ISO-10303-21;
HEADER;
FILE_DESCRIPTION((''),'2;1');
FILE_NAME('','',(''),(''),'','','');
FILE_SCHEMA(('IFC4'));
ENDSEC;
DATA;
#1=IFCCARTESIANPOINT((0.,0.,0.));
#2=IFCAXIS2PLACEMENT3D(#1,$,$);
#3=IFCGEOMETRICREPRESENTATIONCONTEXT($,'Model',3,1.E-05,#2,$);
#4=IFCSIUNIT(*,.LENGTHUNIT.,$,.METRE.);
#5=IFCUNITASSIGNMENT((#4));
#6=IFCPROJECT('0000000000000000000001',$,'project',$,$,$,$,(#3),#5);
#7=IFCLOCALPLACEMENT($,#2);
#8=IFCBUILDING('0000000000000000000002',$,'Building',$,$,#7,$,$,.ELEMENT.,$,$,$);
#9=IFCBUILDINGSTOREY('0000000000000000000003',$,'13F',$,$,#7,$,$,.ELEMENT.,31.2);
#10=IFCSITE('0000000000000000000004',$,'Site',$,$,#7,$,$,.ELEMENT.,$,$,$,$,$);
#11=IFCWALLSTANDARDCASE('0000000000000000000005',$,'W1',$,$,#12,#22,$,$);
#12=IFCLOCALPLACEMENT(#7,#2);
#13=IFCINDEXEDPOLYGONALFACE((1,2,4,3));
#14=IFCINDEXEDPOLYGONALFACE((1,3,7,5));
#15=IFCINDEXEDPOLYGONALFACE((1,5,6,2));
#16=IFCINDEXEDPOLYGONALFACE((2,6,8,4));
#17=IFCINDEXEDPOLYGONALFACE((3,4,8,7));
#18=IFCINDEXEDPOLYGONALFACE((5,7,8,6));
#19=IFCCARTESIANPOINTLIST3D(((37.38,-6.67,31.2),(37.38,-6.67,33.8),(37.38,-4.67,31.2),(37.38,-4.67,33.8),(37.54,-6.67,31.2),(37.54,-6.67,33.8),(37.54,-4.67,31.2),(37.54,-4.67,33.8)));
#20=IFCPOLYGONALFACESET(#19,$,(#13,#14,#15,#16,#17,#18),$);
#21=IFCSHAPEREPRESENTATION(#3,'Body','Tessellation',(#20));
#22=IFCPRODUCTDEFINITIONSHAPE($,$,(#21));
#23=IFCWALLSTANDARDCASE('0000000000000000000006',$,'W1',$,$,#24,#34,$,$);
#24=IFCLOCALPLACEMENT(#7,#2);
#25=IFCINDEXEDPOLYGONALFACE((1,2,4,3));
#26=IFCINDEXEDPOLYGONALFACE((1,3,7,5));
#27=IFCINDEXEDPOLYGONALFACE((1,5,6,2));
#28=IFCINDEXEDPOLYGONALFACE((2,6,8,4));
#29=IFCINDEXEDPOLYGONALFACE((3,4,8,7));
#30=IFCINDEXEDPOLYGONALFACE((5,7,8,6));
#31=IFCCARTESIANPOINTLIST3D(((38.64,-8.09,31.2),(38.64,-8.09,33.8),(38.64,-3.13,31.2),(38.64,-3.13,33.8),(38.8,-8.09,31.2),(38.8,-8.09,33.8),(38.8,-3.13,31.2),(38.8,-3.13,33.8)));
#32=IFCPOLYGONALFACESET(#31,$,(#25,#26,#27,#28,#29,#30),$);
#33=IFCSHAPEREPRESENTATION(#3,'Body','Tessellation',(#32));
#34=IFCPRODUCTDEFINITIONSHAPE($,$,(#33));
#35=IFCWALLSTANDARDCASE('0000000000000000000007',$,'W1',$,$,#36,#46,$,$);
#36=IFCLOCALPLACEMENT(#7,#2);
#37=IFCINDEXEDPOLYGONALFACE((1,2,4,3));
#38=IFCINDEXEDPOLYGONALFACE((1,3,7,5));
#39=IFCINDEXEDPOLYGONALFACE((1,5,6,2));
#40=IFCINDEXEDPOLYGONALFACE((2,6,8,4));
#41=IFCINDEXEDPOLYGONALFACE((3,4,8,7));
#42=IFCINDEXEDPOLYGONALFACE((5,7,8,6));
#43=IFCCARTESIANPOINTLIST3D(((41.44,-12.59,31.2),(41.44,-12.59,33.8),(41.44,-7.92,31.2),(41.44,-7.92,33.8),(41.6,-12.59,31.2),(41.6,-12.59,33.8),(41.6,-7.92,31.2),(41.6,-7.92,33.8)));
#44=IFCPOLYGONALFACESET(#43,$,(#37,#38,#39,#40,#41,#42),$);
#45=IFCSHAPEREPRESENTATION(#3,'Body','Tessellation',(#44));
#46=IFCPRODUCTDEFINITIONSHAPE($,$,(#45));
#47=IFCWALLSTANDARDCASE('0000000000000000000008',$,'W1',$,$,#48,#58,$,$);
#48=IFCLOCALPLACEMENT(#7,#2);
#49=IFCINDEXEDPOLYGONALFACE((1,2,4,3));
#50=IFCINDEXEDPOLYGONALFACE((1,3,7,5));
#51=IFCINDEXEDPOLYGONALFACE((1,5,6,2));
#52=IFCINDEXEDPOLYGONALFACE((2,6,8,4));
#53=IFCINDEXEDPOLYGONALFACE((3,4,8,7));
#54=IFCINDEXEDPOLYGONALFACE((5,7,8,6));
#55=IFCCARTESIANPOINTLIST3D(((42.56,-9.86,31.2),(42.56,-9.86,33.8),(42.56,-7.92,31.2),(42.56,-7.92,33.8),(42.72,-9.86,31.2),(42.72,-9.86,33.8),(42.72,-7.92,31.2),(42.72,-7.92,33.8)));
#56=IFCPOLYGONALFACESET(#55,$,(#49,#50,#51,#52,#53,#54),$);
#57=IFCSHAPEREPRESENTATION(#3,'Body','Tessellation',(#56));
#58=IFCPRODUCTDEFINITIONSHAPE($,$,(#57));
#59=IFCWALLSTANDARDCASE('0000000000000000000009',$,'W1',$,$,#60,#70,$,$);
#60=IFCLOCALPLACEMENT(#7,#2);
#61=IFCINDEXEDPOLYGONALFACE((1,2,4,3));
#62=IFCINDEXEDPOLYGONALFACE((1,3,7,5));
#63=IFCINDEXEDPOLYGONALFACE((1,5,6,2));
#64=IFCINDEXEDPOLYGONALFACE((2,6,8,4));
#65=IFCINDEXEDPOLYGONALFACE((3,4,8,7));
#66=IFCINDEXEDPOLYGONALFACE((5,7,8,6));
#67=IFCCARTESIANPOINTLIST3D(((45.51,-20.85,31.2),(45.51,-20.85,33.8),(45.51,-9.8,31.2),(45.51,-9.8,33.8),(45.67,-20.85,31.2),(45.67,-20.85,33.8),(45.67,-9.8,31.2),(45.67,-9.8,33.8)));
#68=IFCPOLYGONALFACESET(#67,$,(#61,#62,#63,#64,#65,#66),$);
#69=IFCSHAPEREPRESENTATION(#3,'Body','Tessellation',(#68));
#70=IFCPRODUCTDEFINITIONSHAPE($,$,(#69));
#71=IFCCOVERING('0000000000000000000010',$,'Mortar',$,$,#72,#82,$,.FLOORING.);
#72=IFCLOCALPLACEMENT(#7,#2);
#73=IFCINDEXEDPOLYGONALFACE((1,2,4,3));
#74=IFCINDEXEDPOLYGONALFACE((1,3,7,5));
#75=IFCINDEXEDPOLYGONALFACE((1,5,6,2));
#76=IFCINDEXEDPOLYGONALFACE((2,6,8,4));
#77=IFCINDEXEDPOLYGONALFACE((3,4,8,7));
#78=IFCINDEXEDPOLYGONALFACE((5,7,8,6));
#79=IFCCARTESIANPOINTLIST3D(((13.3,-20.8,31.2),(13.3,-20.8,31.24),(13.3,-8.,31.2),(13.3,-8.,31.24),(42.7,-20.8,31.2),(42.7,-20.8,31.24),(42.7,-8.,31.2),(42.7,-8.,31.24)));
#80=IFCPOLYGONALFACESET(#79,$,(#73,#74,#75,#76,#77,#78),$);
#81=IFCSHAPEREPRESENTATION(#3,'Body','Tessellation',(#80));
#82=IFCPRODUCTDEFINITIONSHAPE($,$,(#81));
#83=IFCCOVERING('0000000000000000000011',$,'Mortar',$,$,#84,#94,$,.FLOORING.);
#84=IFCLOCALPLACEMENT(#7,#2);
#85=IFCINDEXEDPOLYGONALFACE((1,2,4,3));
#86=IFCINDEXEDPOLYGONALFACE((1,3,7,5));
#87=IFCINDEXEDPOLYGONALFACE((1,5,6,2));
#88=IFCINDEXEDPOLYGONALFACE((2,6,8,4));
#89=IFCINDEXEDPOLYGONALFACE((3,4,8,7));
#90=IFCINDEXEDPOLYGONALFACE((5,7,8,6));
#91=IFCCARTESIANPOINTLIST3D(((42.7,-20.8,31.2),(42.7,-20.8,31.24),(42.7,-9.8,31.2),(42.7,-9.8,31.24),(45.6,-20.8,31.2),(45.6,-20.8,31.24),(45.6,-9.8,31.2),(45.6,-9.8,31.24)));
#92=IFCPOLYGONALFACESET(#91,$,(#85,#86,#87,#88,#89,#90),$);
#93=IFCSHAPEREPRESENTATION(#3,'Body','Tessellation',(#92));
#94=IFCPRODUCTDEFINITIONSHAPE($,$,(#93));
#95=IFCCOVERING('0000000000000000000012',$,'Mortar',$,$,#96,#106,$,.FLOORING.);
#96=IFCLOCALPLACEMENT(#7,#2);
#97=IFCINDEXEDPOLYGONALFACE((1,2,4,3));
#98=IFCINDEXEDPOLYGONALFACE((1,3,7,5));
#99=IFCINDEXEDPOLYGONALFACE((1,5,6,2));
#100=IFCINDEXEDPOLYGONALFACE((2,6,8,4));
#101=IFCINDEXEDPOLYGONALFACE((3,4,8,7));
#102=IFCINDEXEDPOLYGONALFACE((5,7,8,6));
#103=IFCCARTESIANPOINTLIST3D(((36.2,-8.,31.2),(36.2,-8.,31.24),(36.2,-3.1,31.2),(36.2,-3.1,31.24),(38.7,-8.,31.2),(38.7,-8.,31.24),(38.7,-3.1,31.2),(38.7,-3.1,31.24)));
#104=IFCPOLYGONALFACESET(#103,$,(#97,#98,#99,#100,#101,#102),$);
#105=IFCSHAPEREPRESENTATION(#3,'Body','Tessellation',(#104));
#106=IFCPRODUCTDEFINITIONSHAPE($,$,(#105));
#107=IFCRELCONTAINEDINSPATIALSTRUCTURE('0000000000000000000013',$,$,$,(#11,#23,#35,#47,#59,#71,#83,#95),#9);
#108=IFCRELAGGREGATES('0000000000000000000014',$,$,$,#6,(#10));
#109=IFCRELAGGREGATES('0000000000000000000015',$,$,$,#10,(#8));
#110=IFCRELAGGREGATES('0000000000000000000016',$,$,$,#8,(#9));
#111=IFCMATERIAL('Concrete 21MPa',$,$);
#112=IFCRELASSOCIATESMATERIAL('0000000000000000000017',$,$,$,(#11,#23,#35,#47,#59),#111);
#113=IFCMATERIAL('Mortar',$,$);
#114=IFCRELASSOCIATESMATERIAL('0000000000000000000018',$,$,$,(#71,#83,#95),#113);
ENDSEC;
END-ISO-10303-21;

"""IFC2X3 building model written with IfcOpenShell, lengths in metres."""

from ifc_helpers import new_model, si_unit, frame, origin, origin_2d, place, context, project, spatial, rectangle, extrude, material, element, save


model = new_model("IFC2X3")

# Units and contexts
model_context = context("Model", 3, precision=1e-05, world=origin())
ifc_project = project(units=[si_unit("LENGTHUNIT", "METRE")], contexts=[model_context])

# Site, building, storey
placement = place(None, origin())
site = spatial("IfcSite", under=ifc_project, at=placement, Name="Site", CompositionType="ELEMENT")
building = spatial("IfcBuilding", under=site, at=placement, Name="Building", CompositionType="ELEMENT")
storey = spatial("IfcBuildingStorey", under=building, at=placement, Name="13F", CompositionType="ELEMENT", Elevation=31.2)

# Shared definitions
ifc_material_1 = material(Name="Concrete 21MPa")

# Walls
wall_1_placement = place(None, frame((37.46, -5.67, 31.2)))
element("IfcWallStandardCase", 1, at=wall_1_placement, inside=storey, material=ifc_material_1, Name="W1", context=model_context, shape_type="SweptSolid", body=[
    extrude(rectangle(XDim=0.16, YDim=2.0, at=origin_2d()), origin(), (0.0, 0.0, 1.0), 2.6),
])
wall_2_placement = place(None, frame((38.72, -5.61, 31.2)))
element("IfcWallStandardCase", 2, at=wall_2_placement, inside=storey, material=ifc_material_1, Name="W1", context=model_context, shape_type="SweptSolid", body=[
    extrude(rectangle(XDim=0.16, YDim=4.96, at=origin_2d()), origin(), (0.0, 0.0, 1.0), 2.6),
])
wall_3_placement = place(None, frame((41.52, -10.255, 31.2)))
element("IfcWallStandardCase", 3, at=wall_3_placement, inside=storey, material=ifc_material_1, Name="W1", context=model_context, shape_type="SweptSolid", body=[
    extrude(rectangle(XDim=0.16, YDim=4.67, at=origin_2d()), origin(), (0.0, 0.0, 1.0), 2.6),
])
wall_4_placement = place(None, frame((42.64, -8.89, 31.2)))
element("IfcWallStandardCase", 4, at=wall_4_placement, inside=storey, material=ifc_material_1, Name="W1", context=model_context, shape_type="SweptSolid", body=[
    extrude(rectangle(XDim=0.16, YDim=1.94, at=origin_2d()), origin(), (0.0, 0.0, 1.0), 2.6),
])
wall_5_placement = place(None, frame((45.59, -15.325, 31.2)))
element("IfcWallStandardCase", 5, at=wall_5_placement, inside=storey, material=ifc_material_1, Name="W1", context=model_context, shape_type="SweptSolid", body=[
    extrude(rectangle(XDim=0.16, YDim=11.05, at=origin_2d()), origin(), (0.0, 0.0, 1.0), 2.6),
])

# Coverings
ifc_material_2 = material(Name="Mortar")
covering_1_placement = place(None, frame((28.0, -14.4, 31.2)))
element("IfcCovering", 6, at=covering_1_placement, inside=storey, material=ifc_material_2, Name="Mortar", PredefinedType="FLOORING", context=model_context, shape_type="SweptSolid", body=[
    extrude(rectangle(XDim=29.4, YDim=12.8, at=origin_2d()), origin(), (0.0, 0.0, 1.0), 0.04),
])
covering_2_placement = place(None, frame((44.15, -15.3, 31.2)))
element("IfcCovering", 7, at=covering_2_placement, inside=storey, material=ifc_material_2, Name="Mortar", PredefinedType="FLOORING", context=model_context, shape_type="SweptSolid", body=[
    extrude(rectangle(XDim=2.9, YDim=11.0, at=origin_2d()), origin(), (0.0, 0.0, 1.0), 0.04),
])
covering_3_placement = place(None, frame((37.45, -5.55, 31.2)))
element("IfcCovering", 8, at=covering_3_placement, inside=storey, material=ifc_material_2, Name="Mortar", PredefinedType="FLOORING", context=model_context, shape_type="SweptSolid", body=[
    extrude(rectangle(XDim=2.5, YDim=4.9, at=origin_2d()), origin(), (0.0, 0.0, 1.0), 0.04),
])

save(model, "model.ifc")
